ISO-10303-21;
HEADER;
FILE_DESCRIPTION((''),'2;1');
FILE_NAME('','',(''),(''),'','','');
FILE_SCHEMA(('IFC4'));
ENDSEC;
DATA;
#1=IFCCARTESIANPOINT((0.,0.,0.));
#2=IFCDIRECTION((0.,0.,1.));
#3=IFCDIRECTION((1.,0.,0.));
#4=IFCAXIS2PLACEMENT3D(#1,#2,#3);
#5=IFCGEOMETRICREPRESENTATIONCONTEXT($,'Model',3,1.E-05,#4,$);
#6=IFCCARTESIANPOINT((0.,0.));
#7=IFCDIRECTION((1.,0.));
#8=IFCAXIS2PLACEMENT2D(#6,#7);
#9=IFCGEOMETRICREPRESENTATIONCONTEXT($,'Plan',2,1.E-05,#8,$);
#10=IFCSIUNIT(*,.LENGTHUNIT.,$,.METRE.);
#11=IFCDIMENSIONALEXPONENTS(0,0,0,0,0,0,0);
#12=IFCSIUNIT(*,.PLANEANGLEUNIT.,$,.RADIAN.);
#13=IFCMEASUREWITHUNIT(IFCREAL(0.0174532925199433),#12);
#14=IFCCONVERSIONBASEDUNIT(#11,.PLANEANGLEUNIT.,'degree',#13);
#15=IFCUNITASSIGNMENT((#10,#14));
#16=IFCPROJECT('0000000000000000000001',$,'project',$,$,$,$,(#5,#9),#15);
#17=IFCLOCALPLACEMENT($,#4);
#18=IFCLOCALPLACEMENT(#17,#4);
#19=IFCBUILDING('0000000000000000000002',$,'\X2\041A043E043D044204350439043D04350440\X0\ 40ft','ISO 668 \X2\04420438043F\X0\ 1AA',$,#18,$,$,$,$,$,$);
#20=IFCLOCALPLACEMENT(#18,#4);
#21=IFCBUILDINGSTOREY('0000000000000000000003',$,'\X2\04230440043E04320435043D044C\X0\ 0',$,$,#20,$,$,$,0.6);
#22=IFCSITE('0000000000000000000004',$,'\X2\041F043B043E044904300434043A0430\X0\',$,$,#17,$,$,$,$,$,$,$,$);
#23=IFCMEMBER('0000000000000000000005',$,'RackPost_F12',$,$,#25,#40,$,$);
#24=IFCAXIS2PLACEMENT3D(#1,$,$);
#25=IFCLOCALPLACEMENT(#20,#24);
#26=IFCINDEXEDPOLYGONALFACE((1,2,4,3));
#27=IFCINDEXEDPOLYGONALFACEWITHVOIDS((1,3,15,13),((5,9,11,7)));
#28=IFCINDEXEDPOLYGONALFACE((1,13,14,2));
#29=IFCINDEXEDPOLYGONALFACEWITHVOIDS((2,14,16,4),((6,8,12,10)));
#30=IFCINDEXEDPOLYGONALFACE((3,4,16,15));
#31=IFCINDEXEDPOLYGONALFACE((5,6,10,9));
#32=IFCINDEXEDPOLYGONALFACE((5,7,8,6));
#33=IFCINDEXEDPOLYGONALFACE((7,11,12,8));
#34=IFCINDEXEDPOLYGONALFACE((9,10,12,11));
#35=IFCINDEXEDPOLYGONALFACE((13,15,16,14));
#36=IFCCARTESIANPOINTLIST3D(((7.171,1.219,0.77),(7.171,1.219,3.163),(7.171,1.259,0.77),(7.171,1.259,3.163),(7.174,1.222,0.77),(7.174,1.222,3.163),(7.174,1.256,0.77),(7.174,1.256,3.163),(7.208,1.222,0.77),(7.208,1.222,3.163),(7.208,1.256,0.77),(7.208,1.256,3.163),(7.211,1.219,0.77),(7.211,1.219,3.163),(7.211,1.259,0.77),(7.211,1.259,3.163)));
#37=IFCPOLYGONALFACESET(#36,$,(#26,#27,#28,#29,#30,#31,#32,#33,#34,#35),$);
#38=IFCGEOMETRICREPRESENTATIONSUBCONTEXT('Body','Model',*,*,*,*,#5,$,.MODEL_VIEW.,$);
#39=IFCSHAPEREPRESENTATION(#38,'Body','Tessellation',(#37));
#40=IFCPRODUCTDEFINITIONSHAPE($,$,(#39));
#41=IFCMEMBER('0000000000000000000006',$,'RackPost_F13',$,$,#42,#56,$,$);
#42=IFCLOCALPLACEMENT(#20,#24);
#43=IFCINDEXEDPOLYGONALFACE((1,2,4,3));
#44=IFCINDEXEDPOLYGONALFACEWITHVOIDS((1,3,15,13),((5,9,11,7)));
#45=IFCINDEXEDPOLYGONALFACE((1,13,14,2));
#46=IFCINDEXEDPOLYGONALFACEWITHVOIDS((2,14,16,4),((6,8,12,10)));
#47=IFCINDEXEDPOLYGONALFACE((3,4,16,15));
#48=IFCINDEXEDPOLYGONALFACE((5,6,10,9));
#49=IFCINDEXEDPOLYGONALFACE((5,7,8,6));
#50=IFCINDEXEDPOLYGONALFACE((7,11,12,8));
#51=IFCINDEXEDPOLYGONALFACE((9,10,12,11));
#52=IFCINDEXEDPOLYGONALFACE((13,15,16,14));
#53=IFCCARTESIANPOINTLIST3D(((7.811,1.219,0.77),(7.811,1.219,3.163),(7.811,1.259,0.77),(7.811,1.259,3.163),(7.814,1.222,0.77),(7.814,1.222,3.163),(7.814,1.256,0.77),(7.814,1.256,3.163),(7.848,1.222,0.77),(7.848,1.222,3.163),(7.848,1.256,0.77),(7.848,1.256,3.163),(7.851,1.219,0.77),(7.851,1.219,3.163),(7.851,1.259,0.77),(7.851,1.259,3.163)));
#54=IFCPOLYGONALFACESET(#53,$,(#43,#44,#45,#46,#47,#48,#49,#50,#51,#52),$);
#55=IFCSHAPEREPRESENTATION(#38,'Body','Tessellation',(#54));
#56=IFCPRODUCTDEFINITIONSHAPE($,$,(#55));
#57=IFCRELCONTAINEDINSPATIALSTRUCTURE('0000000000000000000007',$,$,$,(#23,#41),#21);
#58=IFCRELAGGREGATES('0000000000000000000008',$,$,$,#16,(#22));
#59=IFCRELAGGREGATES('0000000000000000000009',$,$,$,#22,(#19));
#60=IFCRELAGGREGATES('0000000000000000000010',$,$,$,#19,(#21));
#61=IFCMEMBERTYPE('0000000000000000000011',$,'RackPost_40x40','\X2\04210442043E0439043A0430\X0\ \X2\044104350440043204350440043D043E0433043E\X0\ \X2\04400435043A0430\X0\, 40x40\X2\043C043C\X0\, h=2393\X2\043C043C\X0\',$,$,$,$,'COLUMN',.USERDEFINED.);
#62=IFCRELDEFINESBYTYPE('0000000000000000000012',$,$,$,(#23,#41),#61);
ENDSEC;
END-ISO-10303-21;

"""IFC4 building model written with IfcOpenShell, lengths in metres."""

from ifc_helpers import new_model, entity, si_unit, converted_unit, frame, origin_with_axes, origin_2d_with_axis, place, context, subcontext, project, spatial, hollow_rectangle, extrude, type_object, element, save


model = new_model("IFC4")

# Units and contexts
model_context = context("Model", 3, precision=1e-05, world=origin_with_axes())
plan_context = context("Plan", 2, precision=1e-05, world=origin_2d_with_axis())
body_context = subcontext(model_context, "Body", "Model", "MODEL_VIEW")
ifc_project = project(units=[si_unit("LENGTHUNIT", "METRE"), converted_unit("PLANEANGLEUNIT", "degree", entity("IfcReal", 0.0174532925199433), si_unit("PLANEANGLEUNIT", "RADIAN"), dimensions=[0, 0, 0, 0, 0, 0, 0])], contexts=[model_context, plan_context])

# Site, building, storey
site_placement = place(None, origin_with_axes())
site = spatial("IfcSite", under=ifc_project, at=site_placement, Name="Площадка")
building_placement = place(site_placement, origin_with_axes())
building = spatial("IfcBuilding", under=site, at=building_placement, Name="Контейнер 40ft", Description="ISO 668 тип 1AA")
storey_placement = place(building_placement, origin_with_axes())
storey = spatial("IfcBuildingStorey", under=building, at=storey_placement, Name="Уровень 0", Elevation=0.6)

# Members
member_type = type_object("IfcMemberType", Name="RackPost_40x40", Description="Стойка серверного река, 40x40мм, h=2393мм", ElementType="COLUMN", PredefinedType="USERDEFINED")
for number, where, z_axis, x_axis, name in (
    (1, (7.191, 1.239, 0.77), (0.0, 0.0, 1.0), (1.0, 0.0, 0.0), "RackPost_F12"),
    (2, (7.831, 1.239, 0.77), (0.0, 0.0, 1.0), (1.0, 0.0, 0.0), "RackPost_F13"),
):
    element("IfcMember", number, at=place(storey_placement, frame(where, z_axis=z_axis, x_axis=x_axis)), inside=storey, type_object=member_type, Name=name, context=body_context, shape_type="SweptSolid", body=[
        extrude(hollow_rectangle(XDim=0.04, YDim=0.04, WallThickness=0.003), origin_with_axes(), (0.0, 0.0, 1.0), 2.393),
    ])

save(model, "model.ifc")
